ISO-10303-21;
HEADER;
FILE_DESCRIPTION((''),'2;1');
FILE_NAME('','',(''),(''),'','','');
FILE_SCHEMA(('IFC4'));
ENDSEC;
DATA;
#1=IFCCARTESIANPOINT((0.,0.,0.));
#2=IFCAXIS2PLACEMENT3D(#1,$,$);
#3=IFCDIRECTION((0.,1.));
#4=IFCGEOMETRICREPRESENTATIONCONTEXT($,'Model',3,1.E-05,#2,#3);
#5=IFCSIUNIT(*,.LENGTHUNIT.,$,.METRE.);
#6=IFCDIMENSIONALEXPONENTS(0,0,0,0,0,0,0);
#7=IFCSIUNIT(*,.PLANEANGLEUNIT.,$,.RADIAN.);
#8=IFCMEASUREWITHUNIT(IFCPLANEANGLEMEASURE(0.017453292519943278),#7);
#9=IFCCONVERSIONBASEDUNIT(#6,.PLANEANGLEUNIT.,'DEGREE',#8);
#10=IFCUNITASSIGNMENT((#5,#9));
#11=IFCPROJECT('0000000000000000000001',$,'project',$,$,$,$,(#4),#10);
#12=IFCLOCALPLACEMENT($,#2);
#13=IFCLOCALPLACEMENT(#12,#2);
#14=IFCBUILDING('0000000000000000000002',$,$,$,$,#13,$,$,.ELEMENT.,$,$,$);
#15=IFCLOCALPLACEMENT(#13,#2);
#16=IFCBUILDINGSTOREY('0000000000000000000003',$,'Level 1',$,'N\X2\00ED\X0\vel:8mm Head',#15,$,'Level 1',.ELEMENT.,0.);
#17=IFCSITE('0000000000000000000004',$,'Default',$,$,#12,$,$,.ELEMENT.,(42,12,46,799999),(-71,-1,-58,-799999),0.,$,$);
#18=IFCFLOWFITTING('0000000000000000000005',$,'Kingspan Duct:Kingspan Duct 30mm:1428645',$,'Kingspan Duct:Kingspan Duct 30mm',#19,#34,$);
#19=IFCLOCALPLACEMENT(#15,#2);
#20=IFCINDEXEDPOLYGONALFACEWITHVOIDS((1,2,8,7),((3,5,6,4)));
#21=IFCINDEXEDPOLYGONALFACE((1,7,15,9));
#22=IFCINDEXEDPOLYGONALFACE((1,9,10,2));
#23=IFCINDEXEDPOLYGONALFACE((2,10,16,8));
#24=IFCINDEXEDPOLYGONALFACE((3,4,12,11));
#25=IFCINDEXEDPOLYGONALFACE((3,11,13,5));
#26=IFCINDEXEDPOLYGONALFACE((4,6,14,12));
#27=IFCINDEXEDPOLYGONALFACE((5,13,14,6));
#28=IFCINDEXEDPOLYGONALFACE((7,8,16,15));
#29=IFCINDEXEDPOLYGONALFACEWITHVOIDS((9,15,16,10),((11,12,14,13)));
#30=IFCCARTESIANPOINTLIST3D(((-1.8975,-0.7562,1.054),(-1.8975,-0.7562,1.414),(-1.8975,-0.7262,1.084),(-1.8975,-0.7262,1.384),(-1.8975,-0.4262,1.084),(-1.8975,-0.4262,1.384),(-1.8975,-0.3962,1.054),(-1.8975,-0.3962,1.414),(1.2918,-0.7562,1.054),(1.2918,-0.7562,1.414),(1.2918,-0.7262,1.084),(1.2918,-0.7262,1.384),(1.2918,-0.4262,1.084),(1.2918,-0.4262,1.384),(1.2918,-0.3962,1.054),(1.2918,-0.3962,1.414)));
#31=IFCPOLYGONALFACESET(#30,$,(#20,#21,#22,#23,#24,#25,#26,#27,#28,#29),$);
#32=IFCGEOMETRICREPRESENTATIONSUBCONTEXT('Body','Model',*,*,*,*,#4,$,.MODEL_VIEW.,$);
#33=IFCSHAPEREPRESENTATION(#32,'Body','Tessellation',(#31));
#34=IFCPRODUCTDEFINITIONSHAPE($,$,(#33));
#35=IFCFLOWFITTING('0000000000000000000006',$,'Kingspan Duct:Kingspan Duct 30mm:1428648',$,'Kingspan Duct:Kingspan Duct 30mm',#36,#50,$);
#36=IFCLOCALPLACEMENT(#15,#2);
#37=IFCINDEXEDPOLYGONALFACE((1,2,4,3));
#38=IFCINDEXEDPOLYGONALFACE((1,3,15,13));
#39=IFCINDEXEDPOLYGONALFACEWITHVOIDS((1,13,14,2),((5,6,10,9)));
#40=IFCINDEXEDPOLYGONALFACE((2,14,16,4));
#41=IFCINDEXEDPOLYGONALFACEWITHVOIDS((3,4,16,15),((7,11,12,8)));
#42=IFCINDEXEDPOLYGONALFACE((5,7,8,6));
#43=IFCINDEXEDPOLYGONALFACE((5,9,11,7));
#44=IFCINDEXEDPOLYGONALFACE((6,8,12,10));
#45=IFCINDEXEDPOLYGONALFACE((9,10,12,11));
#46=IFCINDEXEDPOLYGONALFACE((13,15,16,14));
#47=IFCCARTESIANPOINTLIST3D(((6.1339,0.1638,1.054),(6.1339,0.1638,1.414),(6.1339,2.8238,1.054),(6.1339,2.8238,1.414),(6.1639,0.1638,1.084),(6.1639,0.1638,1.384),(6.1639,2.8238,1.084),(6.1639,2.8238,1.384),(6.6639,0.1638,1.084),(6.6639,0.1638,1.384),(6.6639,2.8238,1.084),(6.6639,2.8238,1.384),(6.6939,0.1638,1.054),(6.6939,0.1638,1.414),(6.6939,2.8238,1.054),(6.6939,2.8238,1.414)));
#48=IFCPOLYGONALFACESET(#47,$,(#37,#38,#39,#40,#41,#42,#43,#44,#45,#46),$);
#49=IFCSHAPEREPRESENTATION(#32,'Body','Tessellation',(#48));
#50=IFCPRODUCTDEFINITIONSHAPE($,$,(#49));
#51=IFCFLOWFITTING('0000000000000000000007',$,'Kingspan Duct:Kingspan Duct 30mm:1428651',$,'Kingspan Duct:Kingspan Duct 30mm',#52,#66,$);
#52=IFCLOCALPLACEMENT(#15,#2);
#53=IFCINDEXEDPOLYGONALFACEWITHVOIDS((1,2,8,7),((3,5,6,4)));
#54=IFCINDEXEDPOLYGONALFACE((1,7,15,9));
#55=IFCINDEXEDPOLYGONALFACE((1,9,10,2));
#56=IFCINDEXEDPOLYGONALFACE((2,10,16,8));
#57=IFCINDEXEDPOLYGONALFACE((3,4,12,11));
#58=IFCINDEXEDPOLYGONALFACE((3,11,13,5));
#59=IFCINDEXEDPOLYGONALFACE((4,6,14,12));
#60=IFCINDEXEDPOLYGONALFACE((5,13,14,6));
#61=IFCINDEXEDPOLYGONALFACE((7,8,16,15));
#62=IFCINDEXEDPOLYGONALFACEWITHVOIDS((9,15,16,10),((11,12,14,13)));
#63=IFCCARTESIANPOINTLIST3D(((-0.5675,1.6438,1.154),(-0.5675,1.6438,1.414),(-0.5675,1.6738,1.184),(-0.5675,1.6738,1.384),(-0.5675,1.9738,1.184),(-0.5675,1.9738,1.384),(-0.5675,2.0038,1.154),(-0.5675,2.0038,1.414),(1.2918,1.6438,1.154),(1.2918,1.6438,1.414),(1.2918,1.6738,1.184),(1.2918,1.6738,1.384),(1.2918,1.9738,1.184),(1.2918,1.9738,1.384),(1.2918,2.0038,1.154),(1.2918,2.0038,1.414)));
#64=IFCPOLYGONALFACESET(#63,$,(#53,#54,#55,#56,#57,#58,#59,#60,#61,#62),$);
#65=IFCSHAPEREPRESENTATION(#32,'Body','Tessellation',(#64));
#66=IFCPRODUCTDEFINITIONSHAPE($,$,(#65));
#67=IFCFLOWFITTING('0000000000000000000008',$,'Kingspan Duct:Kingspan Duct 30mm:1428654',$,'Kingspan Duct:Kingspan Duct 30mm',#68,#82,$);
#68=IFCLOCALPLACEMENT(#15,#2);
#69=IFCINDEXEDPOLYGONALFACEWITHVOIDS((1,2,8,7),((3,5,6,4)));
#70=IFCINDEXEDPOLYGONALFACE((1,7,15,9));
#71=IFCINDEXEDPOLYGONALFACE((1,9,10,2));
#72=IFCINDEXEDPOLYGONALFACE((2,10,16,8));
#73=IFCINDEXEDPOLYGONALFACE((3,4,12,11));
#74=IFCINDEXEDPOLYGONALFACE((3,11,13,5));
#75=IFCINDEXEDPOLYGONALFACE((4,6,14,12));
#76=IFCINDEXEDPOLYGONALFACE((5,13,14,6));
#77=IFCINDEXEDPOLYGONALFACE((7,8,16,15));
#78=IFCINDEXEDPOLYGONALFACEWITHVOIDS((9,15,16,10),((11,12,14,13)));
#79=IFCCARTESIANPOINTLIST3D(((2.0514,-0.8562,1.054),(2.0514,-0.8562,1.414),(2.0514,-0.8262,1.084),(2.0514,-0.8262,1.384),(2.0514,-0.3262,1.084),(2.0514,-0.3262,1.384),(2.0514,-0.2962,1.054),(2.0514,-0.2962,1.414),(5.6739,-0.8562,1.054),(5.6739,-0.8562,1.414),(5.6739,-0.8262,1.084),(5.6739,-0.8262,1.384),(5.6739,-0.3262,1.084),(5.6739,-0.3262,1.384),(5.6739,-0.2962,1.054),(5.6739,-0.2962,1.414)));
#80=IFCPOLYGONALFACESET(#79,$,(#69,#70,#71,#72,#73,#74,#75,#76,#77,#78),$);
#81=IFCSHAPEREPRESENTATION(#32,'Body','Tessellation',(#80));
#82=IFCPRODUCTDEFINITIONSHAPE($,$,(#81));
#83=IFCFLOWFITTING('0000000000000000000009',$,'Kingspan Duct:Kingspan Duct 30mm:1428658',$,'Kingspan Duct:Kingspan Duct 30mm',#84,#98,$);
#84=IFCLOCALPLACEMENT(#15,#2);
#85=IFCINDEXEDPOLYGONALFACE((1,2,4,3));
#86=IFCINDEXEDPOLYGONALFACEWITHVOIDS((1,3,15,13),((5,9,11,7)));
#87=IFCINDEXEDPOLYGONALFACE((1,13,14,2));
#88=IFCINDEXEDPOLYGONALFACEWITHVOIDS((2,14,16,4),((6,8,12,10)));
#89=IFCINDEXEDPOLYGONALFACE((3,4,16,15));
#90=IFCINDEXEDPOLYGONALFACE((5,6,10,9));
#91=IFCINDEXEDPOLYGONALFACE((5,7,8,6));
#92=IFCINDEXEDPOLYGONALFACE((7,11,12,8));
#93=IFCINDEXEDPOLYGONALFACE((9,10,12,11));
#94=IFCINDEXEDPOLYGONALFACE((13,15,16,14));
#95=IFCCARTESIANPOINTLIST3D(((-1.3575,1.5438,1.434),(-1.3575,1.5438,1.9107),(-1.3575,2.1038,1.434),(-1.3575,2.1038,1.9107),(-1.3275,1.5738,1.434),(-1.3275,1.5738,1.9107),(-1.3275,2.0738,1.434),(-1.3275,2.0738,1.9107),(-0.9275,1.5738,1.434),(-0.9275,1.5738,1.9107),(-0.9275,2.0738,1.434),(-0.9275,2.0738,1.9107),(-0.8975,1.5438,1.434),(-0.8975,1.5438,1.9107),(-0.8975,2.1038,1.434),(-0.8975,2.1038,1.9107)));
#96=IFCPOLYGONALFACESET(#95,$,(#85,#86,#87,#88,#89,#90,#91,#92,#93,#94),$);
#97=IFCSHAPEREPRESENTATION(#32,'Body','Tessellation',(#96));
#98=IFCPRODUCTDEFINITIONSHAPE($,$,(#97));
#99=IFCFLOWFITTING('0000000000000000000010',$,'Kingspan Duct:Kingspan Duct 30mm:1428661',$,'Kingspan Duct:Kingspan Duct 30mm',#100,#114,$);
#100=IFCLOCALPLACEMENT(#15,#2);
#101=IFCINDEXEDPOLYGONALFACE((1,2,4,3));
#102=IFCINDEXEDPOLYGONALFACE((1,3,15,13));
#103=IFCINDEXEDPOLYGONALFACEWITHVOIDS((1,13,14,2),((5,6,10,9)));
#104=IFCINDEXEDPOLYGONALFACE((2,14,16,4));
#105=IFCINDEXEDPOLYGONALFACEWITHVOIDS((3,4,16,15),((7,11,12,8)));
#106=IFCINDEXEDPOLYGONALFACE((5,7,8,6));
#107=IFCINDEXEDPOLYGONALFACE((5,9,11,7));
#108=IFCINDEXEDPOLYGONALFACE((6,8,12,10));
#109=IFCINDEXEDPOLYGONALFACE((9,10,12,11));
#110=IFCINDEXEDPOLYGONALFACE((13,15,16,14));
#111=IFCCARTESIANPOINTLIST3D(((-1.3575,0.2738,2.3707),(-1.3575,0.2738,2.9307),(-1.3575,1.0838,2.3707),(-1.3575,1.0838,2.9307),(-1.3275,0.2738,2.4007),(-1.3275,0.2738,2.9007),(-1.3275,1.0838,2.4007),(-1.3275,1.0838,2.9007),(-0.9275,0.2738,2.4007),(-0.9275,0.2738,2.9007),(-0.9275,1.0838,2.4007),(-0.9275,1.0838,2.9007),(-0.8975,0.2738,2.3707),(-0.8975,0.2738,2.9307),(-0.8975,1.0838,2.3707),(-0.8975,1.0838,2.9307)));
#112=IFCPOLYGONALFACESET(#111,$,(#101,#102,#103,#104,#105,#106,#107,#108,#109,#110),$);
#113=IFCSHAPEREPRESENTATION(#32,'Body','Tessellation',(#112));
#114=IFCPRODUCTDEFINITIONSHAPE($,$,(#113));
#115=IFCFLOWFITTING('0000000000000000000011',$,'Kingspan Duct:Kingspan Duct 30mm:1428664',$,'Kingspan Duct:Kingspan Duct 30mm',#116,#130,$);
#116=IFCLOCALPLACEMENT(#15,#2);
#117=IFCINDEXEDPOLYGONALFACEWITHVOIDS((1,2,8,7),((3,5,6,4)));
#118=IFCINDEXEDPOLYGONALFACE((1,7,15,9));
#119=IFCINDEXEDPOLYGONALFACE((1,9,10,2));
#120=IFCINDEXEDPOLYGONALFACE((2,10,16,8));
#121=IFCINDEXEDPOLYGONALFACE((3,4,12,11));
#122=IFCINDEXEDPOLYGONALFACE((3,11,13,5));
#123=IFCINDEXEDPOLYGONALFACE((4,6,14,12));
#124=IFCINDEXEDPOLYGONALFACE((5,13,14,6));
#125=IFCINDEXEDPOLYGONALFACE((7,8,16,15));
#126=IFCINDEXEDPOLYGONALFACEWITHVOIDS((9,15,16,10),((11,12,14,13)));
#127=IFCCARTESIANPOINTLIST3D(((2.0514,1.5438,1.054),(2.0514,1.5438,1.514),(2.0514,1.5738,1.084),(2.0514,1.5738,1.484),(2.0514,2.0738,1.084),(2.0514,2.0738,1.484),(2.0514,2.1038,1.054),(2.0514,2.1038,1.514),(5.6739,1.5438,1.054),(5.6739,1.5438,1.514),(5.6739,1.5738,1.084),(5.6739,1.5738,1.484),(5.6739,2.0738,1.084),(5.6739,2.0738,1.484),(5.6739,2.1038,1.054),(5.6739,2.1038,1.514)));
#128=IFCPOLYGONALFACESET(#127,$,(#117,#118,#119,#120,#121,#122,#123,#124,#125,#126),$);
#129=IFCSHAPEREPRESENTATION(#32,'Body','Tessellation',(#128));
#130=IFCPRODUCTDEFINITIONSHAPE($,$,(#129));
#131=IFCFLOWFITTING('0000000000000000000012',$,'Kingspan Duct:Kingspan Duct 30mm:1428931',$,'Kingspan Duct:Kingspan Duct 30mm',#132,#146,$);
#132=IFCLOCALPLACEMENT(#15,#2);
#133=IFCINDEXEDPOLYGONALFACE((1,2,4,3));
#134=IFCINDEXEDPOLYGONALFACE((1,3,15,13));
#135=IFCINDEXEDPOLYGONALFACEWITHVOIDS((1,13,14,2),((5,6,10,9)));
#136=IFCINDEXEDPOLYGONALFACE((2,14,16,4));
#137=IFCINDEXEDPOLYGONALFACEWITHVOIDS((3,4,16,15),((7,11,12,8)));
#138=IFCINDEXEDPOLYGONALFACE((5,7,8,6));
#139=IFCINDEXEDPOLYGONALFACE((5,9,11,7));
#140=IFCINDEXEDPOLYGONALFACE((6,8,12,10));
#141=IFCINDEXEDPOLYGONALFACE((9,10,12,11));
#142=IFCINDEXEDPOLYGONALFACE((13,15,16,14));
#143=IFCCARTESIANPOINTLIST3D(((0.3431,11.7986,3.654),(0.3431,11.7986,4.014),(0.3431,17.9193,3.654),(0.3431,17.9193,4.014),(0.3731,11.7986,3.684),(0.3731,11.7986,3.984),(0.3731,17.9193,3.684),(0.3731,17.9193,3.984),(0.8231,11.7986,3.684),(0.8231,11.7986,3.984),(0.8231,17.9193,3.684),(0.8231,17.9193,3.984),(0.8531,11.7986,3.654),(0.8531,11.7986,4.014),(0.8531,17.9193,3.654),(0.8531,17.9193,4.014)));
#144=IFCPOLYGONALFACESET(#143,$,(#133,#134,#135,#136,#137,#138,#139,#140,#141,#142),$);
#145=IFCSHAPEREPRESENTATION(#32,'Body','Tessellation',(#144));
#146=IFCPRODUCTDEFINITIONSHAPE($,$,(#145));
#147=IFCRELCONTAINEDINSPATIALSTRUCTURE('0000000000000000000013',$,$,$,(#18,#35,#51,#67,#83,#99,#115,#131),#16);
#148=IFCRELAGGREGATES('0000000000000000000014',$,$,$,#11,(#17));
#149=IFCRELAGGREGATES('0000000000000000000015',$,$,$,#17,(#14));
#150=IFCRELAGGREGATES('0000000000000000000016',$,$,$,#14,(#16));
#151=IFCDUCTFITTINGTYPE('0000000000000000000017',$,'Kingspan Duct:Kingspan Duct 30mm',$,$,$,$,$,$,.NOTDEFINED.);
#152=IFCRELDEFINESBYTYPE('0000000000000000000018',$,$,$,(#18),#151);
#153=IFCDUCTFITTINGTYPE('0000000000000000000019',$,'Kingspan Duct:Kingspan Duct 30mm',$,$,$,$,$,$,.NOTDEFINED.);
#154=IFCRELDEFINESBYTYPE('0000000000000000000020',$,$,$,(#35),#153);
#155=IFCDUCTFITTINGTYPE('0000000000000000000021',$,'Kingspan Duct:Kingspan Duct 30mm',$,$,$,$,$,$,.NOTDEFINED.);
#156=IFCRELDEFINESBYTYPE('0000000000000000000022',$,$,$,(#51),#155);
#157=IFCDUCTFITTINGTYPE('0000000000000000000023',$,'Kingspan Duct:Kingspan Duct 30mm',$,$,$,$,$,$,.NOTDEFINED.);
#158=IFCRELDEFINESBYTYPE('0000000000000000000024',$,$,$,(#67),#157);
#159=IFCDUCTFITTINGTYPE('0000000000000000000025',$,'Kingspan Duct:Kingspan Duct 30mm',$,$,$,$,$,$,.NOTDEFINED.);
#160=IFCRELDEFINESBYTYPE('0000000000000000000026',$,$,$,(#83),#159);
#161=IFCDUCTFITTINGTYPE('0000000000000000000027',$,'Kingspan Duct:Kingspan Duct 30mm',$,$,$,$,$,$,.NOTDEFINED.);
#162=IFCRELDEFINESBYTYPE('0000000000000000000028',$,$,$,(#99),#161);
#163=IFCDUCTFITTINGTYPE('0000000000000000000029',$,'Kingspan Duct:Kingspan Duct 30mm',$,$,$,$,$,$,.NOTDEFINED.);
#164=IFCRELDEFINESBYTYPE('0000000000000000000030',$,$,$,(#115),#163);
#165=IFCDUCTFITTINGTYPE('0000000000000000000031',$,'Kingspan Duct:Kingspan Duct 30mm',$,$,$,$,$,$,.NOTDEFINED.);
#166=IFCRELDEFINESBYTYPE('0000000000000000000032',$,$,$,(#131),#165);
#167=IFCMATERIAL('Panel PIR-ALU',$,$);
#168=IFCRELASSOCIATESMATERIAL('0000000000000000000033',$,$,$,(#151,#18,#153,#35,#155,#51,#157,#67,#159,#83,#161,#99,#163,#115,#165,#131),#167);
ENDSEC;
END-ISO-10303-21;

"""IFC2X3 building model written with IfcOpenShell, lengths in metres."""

from ifc_helpers import new_model, entity, si_unit, converted_unit, direction, frame, origin, place, context, subcontext, project, spatial, polyline, outline, extrude, source, transform, mapped, material, type_object, type_shapes, element, save


model = new_model("IFC2X3")

# Units and contexts
model_context = context("Model", 3, precision=1e-05, world=origin(), true_north=direction((0.0, 1.0)))
body_context = subcontext(model_context, "Body", "Model", "MODEL_VIEW")
ifc_project = project(units=[si_unit("LENGTHUNIT", "METRE"), converted_unit("PLANEANGLEUNIT", "DEGREE", entity("IfcPlaneAngleMeasure", 0.017453292519943278), si_unit("PLANEANGLEUNIT", "RADIAN"), dimensions=[0, 0, 0, 0, 0, 0, 0])], contexts=[model_context])

# Site, building, storey
site_placement = place(None, origin())
site = spatial("IfcSite", under=ifc_project, at=site_placement, Name="Default", CompositionType="ELEMENT", RefLatitude=(42, 12, 46, 799999), RefLongitude=(-71, -1, -58, -799999), RefElevation=0.0)
building_placement = place(site_placement, origin())
building = spatial("IfcBuilding", under=site, at=building_placement, CompositionType="ELEMENT")
storey_placement = place(building_placement, origin())
storey = spatial("IfcBuildingStorey", under=building, at=storey_placement, Name="Level 1", ObjectType="Nível:8mm Head", LongName="Level 1", CompositionType="ELEMENT", Elevation=0.0)

# Flow fittings
ifc_material = material(Name="Panel PIR-ALU")
duct_fitting_type_1 = type_object("IfcDuctFittingType", Name="Kingspan Duct:Kingspan Duct 30mm", PredefinedType="NOTDEFINED", material=ifc_material)
shared_shape_1 = source(origin(), body_context, "Body", "SweptSolid", [
    extrude(outline(polyline([(-0.18, -0.18), (0.18, -0.18), (0.18, 0.18), (-0.18, 0.18), (-0.18, -0.18)]), holes=[polyline([(-0.15, -0.15), (-0.15, 0.15), (0.15, 0.15), (0.15, -0.15), (-0.15, -0.15)])]), frame((0.0, 0.0, -0.15), z_axis=(1.0, 0.0, 0.0), x_axis=(0.0, -1.0, 0.0)), (0.0, 0.0, 1.0), 3.1893),
])
type_shapes(duct_fitting_type_1, [shared_shape_1])
flow_fitting_1_placement = place(storey_placement, frame((-1.8975, -0.5762, 1.084), z_axis=(0.0, 0.0, -1.0), x_axis=(1.0, 0.0, 0.0)))
element("IfcFlowFitting", 1, at=flow_fitting_1_placement, inside=storey, type_object=duct_fitting_type_1, material=ifc_material, Name="Kingspan Duct:Kingspan Duct 30mm:1428645", ObjectType="Kingspan Duct:Kingspan Duct 30mm", context=body_context, shape_type="MappedRepresentation", body=[
    mapped(shared_shape_1, transform((0.0, 0.0, 0.0), scale=1.0)),
])
duct_fitting_type_2 = type_object("IfcDuctFittingType", Name="Kingspan Duct:Kingspan Duct 30mm", PredefinedType="NOTDEFINED", material=ifc_material)
shared_shape_2 = source(origin(), body_context, "Body", "SweptSolid", [
    extrude(outline(polyline([(-0.28, -0.18), (0.28, -0.18), (0.28, 0.18), (-0.28, 0.18), (-0.28, -0.18)]), holes=[polyline([(-0.25, -0.15), (-0.25, 0.15), (0.25, 0.15), (0.25, -0.15), (-0.25, -0.15)])]), frame((0.0, 0.0, -0.15), z_axis=(1.0, 0.0, 0.0), x_axis=(0.0, -1.0, 0.0)), (0.0, 0.0, 1.0), 2.66),
])
type_shapes(duct_fitting_type_2, [shared_shape_2])
flow_fitting_2_placement = place(storey_placement, frame((6.4139, 0.1638, 1.084), z_axis=(0.0, 0.0, -1.0), x_axis=(0.0, 1.0, 0.0)))
element("IfcFlowFitting", 2, at=flow_fitting_2_placement, inside=storey, type_object=duct_fitting_type_2, material=ifc_material, Name="Kingspan Duct:Kingspan Duct 30mm:1428648", ObjectType="Kingspan Duct:Kingspan Duct 30mm", context=body_context, shape_type="MappedRepresentation", body=[
    mapped(shared_shape_2, transform((0.0, 0.0, 0.0), scale=1.0)),
])
duct_fitting_type_3 = type_object("IfcDuctFittingType", Name="Kingspan Duct:Kingspan Duct 30mm", PredefinedType="NOTDEFINED", material=ifc_material)
shared_shape_3 = source(origin(), body_context, "Body", "SweptSolid", [
    extrude(outline(polyline([(-0.18, -0.13), (0.18, -0.13), (0.18, 0.13), (-0.18, 0.13), (-0.18, -0.13)]), holes=[polyline([(-0.15, -0.1), (-0.15, 0.1), (0.15, 0.1), (0.15, -0.1), (-0.15, -0.1)])]), frame((0.0, 0.0, -0.1), z_axis=(1.0, 0.0, 0.0), x_axis=(0.0, -1.0, 0.0)), (0.0, 0.0, 1.0), 1.8593),
])
type_shapes(duct_fitting_type_3, [shared_shape_3])
flow_fitting_3_placement = place(storey_placement, frame((1.2918, 1.8238, 1.184), z_axis=(0.0, 0.0, -1.0), x_axis=(-1.0, 0.0, 0.0)))
element("IfcFlowFitting", 3, at=flow_fitting_3_placement, inside=storey, type_object=duct_fitting_type_3, material=ifc_material, Name="Kingspan Duct:Kingspan Duct 30mm:1428651", ObjectType="Kingspan Duct:Kingspan Duct 30mm", context=body_context, shape_type="MappedRepresentation", body=[
    mapped(shared_shape_3, transform((0.0, 0.0, 0.0), scale=1.0)),
])
duct_fitting_type_4 = type_object("IfcDuctFittingType", Name="Kingspan Duct:Kingspan Duct 30mm", PredefinedType="NOTDEFINED", material=ifc_material)
shared_shape_4 = source(origin(), body_context, "Body", "SweptSolid", [
    extrude(outline(polyline([(-0.28, -0.18), (0.28, -0.18), (0.28, 0.18), (-0.28, 0.18), (-0.28, -0.18)]), holes=[polyline([(-0.25, -0.15), (-0.25, 0.15), (0.25, 0.15), (0.25, -0.15), (-0.25, -0.15)])]), frame((0.0, 0.0, -0.15), z_axis=(1.0, 0.0, 0.0), x_axis=(0.0, -1.0, 0.0)), (0.0, 0.0, 1.0), 3.6225),
])
type_shapes(duct_fitting_type_4, [shared_shape_4])
flow_fitting_4_placement = place(storey_placement, frame((2.0514, -0.5762, 1.084), z_axis=(0.0, 0.0, -1.0), x_axis=(1.0, 0.0, 0.0)))
element("IfcFlowFitting", 4, at=flow_fitting_4_placement, inside=storey, type_object=duct_fitting_type_4, material=ifc_material, Name="Kingspan Duct:Kingspan Duct 30mm:1428654", ObjectType="Kingspan Duct:Kingspan Duct 30mm", context=body_context, shape_type="MappedRepresentation", body=[
    mapped(shared_shape_4, transform((0.0, 0.0, 0.0), scale=1.0)),
])
duct_fitting_type_5 = type_object("IfcDuctFittingType", Name="Kingspan Duct:Kingspan Duct 30mm", PredefinedType="NOTDEFINED", material=ifc_material)
shared_shape_5 = source(origin(), body_context, "Body", "SweptSolid", [
    extrude(outline(polyline([(-0.23, -0.28), (0.23, -0.28), (0.23, 0.28), (-0.23, 0.28), (-0.23, -0.28)]), holes=[polyline([(-0.2, -0.25), (-0.2, 0.25), (0.2, 0.25), (0.2, -0.25), (-0.2, -0.25)])]), frame((0.0, 0.0, -0.25), z_axis=(1.0, 0.0, 0.0), x_axis=(0.0, -1.0, 0.0)), (0.0, 0.0, 1.0), 0.4767),
])
type_shapes(duct_fitting_type_5, [shared_shape_5])
flow_fitting_5_placement = place(storey_placement, frame((-1.1275, 2.0738, 1.434), z_axis=(0.0, 1.0, 0.0), x_axis=(0.0, 0.0, 1.0)))
element("IfcFlowFitting", 5, at=flow_fitting_5_placement, inside=storey, type_object=duct_fitting_type_5, material=ifc_material, Name="Kingspan Duct:Kingspan Duct 30mm:1428658", ObjectType="Kingspan Duct:Kingspan Duct 30mm", context=body_context, shape_type="MappedRepresentation", body=[
    mapped(shared_shape_5, transform((0.0, 0.0, 0.0), scale=1.0)),
])
duct_fitting_type_6 = type_object("IfcDuctFittingType", Name="Kingspan Duct:Kingspan Duct 30mm", PredefinedType="NOTDEFINED", material=ifc_material)
shared_shape_6 = source(origin(), body_context, "Body", "SweptSolid", [
    extrude(outline(polyline([(-0.23, -0.28), (0.23, -0.28), (0.23, 0.28), (-0.23, 0.28), (-0.23, -0.28)]), holes=[polyline([(-0.2, -0.25), (-0.2, 0.25), (0.2, 0.25), (0.2, -0.25), (-0.2, -0.25)])]), frame((0.0, 0.0, -0.25), z_axis=(1.0, 0.0, 0.0), x_axis=(0.0, -1.0, 0.0)), (0.0, 0.0, 1.0), 0.81),
])
type_shapes(duct_fitting_type_6, [shared_shape_6])
flow_fitting_6_placement = place(storey_placement, frame((-1.1275, 1.0838, 2.4007), z_axis=(0.0, 0.0, -1.0), x_axis=(0.0, -1.0, 0.0)))
element("IfcFlowFitting", 6, at=flow_fitting_6_placement, inside=storey, type_object=duct_fitting_type_6, material=ifc_material, Name="Kingspan Duct:Kingspan Duct 30mm:1428661", ObjectType="Kingspan Duct:Kingspan Duct 30mm", context=body_context, shape_type="MappedRepresentation", body=[
    mapped(shared_shape_6, transform((0.0, 0.0, 0.0), scale=1.0)),
])
duct_fitting_type_7 = type_object("IfcDuctFittingType", Name="Kingspan Duct:Kingspan Duct 30mm", PredefinedType="NOTDEFINED", material=ifc_material)
shared_shape_7 = source(origin(), body_context, "Body", "SweptSolid", [
    extrude(outline(polyline([(-0.28, -0.23), (0.28, -0.23), (0.28, 0.23), (-0.28, 0.23), (-0.28, -0.23)]), holes=[polyline([(-0.25, -0.2), (-0.25, 0.2), (0.25, 0.2), (0.25, -0.2), (-0.25, -0.2)])]), frame((0.0, 0.0, -0.2), z_axis=(1.0, 0.0, 0.0), x_axis=(0.0, -1.0, 0.0)), (0.0, 0.0, 1.0), 3.6226),
])
type_shapes(duct_fitting_type_7, [shared_shape_7])
flow_fitting_7_placement = place(storey_placement, frame((2.0514, 1.8238, 1.084), z_axis=(0.0, 0.0, -1.0), x_axis=(1.0, 0.0, 0.0)))
element("IfcFlowFitting", 7, at=flow_fitting_7_placement, inside=storey, type_object=duct_fitting_type_7, material=ifc_material, Name="Kingspan Duct:Kingspan Duct 30mm:1428664", ObjectType="Kingspan Duct:Kingspan Duct 30mm", context=body_context, shape_type="MappedRepresentation", body=[
    mapped(shared_shape_7, transform((0.0, 0.0, 0.0), scale=1.0)),
])
duct_fitting_type_8 = type_object("IfcDuctFittingType", Name="Kingspan Duct:Kingspan Duct 30mm", PredefinedType="NOTDEFINED", material=ifc_material)
shared_shape_8 = source(origin(), body_context, "Body", "SweptSolid", [
    extrude(outline(polyline([(-0.255, -0.18), (0.255, -0.18), (0.255, 0.18), (-0.255, 0.18), (-0.255, -0.18)]), holes=[polyline([(-0.225, -0.15), (-0.225, 0.15), (0.225, 0.15), (0.225, -0.15), (-0.225, -0.15)])]), frame((0.0, 0.0, -0.15), z_axis=(1.0, 0.0, 0.0), x_axis=(0.0, -1.0, 0.0)), (0.0, 0.0, 1.0), 6.1206),
])
type_shapes(duct_fitting_type_8, [shared_shape_8])
flow_fitting_8_placement = place(storey_placement, frame((0.5981, 17.9193, 3.684), z_axis=(0.0, 0.0, -1.0), x_axis=(0.0, -1.0, 0.0)))
element("IfcFlowFitting", 8, at=flow_fitting_8_placement, inside=storey, type_object=duct_fitting_type_8, material=ifc_material, Name="Kingspan Duct:Kingspan Duct 30mm:1428931", ObjectType="Kingspan Duct:Kingspan Duct 30mm", context=body_context, shape_type="MappedRepresentation", body=[
    mapped(shared_shape_8, transform((0.0, 0.0, 0.0), scale=1.0)),
])

save(model, "model.ifc")
